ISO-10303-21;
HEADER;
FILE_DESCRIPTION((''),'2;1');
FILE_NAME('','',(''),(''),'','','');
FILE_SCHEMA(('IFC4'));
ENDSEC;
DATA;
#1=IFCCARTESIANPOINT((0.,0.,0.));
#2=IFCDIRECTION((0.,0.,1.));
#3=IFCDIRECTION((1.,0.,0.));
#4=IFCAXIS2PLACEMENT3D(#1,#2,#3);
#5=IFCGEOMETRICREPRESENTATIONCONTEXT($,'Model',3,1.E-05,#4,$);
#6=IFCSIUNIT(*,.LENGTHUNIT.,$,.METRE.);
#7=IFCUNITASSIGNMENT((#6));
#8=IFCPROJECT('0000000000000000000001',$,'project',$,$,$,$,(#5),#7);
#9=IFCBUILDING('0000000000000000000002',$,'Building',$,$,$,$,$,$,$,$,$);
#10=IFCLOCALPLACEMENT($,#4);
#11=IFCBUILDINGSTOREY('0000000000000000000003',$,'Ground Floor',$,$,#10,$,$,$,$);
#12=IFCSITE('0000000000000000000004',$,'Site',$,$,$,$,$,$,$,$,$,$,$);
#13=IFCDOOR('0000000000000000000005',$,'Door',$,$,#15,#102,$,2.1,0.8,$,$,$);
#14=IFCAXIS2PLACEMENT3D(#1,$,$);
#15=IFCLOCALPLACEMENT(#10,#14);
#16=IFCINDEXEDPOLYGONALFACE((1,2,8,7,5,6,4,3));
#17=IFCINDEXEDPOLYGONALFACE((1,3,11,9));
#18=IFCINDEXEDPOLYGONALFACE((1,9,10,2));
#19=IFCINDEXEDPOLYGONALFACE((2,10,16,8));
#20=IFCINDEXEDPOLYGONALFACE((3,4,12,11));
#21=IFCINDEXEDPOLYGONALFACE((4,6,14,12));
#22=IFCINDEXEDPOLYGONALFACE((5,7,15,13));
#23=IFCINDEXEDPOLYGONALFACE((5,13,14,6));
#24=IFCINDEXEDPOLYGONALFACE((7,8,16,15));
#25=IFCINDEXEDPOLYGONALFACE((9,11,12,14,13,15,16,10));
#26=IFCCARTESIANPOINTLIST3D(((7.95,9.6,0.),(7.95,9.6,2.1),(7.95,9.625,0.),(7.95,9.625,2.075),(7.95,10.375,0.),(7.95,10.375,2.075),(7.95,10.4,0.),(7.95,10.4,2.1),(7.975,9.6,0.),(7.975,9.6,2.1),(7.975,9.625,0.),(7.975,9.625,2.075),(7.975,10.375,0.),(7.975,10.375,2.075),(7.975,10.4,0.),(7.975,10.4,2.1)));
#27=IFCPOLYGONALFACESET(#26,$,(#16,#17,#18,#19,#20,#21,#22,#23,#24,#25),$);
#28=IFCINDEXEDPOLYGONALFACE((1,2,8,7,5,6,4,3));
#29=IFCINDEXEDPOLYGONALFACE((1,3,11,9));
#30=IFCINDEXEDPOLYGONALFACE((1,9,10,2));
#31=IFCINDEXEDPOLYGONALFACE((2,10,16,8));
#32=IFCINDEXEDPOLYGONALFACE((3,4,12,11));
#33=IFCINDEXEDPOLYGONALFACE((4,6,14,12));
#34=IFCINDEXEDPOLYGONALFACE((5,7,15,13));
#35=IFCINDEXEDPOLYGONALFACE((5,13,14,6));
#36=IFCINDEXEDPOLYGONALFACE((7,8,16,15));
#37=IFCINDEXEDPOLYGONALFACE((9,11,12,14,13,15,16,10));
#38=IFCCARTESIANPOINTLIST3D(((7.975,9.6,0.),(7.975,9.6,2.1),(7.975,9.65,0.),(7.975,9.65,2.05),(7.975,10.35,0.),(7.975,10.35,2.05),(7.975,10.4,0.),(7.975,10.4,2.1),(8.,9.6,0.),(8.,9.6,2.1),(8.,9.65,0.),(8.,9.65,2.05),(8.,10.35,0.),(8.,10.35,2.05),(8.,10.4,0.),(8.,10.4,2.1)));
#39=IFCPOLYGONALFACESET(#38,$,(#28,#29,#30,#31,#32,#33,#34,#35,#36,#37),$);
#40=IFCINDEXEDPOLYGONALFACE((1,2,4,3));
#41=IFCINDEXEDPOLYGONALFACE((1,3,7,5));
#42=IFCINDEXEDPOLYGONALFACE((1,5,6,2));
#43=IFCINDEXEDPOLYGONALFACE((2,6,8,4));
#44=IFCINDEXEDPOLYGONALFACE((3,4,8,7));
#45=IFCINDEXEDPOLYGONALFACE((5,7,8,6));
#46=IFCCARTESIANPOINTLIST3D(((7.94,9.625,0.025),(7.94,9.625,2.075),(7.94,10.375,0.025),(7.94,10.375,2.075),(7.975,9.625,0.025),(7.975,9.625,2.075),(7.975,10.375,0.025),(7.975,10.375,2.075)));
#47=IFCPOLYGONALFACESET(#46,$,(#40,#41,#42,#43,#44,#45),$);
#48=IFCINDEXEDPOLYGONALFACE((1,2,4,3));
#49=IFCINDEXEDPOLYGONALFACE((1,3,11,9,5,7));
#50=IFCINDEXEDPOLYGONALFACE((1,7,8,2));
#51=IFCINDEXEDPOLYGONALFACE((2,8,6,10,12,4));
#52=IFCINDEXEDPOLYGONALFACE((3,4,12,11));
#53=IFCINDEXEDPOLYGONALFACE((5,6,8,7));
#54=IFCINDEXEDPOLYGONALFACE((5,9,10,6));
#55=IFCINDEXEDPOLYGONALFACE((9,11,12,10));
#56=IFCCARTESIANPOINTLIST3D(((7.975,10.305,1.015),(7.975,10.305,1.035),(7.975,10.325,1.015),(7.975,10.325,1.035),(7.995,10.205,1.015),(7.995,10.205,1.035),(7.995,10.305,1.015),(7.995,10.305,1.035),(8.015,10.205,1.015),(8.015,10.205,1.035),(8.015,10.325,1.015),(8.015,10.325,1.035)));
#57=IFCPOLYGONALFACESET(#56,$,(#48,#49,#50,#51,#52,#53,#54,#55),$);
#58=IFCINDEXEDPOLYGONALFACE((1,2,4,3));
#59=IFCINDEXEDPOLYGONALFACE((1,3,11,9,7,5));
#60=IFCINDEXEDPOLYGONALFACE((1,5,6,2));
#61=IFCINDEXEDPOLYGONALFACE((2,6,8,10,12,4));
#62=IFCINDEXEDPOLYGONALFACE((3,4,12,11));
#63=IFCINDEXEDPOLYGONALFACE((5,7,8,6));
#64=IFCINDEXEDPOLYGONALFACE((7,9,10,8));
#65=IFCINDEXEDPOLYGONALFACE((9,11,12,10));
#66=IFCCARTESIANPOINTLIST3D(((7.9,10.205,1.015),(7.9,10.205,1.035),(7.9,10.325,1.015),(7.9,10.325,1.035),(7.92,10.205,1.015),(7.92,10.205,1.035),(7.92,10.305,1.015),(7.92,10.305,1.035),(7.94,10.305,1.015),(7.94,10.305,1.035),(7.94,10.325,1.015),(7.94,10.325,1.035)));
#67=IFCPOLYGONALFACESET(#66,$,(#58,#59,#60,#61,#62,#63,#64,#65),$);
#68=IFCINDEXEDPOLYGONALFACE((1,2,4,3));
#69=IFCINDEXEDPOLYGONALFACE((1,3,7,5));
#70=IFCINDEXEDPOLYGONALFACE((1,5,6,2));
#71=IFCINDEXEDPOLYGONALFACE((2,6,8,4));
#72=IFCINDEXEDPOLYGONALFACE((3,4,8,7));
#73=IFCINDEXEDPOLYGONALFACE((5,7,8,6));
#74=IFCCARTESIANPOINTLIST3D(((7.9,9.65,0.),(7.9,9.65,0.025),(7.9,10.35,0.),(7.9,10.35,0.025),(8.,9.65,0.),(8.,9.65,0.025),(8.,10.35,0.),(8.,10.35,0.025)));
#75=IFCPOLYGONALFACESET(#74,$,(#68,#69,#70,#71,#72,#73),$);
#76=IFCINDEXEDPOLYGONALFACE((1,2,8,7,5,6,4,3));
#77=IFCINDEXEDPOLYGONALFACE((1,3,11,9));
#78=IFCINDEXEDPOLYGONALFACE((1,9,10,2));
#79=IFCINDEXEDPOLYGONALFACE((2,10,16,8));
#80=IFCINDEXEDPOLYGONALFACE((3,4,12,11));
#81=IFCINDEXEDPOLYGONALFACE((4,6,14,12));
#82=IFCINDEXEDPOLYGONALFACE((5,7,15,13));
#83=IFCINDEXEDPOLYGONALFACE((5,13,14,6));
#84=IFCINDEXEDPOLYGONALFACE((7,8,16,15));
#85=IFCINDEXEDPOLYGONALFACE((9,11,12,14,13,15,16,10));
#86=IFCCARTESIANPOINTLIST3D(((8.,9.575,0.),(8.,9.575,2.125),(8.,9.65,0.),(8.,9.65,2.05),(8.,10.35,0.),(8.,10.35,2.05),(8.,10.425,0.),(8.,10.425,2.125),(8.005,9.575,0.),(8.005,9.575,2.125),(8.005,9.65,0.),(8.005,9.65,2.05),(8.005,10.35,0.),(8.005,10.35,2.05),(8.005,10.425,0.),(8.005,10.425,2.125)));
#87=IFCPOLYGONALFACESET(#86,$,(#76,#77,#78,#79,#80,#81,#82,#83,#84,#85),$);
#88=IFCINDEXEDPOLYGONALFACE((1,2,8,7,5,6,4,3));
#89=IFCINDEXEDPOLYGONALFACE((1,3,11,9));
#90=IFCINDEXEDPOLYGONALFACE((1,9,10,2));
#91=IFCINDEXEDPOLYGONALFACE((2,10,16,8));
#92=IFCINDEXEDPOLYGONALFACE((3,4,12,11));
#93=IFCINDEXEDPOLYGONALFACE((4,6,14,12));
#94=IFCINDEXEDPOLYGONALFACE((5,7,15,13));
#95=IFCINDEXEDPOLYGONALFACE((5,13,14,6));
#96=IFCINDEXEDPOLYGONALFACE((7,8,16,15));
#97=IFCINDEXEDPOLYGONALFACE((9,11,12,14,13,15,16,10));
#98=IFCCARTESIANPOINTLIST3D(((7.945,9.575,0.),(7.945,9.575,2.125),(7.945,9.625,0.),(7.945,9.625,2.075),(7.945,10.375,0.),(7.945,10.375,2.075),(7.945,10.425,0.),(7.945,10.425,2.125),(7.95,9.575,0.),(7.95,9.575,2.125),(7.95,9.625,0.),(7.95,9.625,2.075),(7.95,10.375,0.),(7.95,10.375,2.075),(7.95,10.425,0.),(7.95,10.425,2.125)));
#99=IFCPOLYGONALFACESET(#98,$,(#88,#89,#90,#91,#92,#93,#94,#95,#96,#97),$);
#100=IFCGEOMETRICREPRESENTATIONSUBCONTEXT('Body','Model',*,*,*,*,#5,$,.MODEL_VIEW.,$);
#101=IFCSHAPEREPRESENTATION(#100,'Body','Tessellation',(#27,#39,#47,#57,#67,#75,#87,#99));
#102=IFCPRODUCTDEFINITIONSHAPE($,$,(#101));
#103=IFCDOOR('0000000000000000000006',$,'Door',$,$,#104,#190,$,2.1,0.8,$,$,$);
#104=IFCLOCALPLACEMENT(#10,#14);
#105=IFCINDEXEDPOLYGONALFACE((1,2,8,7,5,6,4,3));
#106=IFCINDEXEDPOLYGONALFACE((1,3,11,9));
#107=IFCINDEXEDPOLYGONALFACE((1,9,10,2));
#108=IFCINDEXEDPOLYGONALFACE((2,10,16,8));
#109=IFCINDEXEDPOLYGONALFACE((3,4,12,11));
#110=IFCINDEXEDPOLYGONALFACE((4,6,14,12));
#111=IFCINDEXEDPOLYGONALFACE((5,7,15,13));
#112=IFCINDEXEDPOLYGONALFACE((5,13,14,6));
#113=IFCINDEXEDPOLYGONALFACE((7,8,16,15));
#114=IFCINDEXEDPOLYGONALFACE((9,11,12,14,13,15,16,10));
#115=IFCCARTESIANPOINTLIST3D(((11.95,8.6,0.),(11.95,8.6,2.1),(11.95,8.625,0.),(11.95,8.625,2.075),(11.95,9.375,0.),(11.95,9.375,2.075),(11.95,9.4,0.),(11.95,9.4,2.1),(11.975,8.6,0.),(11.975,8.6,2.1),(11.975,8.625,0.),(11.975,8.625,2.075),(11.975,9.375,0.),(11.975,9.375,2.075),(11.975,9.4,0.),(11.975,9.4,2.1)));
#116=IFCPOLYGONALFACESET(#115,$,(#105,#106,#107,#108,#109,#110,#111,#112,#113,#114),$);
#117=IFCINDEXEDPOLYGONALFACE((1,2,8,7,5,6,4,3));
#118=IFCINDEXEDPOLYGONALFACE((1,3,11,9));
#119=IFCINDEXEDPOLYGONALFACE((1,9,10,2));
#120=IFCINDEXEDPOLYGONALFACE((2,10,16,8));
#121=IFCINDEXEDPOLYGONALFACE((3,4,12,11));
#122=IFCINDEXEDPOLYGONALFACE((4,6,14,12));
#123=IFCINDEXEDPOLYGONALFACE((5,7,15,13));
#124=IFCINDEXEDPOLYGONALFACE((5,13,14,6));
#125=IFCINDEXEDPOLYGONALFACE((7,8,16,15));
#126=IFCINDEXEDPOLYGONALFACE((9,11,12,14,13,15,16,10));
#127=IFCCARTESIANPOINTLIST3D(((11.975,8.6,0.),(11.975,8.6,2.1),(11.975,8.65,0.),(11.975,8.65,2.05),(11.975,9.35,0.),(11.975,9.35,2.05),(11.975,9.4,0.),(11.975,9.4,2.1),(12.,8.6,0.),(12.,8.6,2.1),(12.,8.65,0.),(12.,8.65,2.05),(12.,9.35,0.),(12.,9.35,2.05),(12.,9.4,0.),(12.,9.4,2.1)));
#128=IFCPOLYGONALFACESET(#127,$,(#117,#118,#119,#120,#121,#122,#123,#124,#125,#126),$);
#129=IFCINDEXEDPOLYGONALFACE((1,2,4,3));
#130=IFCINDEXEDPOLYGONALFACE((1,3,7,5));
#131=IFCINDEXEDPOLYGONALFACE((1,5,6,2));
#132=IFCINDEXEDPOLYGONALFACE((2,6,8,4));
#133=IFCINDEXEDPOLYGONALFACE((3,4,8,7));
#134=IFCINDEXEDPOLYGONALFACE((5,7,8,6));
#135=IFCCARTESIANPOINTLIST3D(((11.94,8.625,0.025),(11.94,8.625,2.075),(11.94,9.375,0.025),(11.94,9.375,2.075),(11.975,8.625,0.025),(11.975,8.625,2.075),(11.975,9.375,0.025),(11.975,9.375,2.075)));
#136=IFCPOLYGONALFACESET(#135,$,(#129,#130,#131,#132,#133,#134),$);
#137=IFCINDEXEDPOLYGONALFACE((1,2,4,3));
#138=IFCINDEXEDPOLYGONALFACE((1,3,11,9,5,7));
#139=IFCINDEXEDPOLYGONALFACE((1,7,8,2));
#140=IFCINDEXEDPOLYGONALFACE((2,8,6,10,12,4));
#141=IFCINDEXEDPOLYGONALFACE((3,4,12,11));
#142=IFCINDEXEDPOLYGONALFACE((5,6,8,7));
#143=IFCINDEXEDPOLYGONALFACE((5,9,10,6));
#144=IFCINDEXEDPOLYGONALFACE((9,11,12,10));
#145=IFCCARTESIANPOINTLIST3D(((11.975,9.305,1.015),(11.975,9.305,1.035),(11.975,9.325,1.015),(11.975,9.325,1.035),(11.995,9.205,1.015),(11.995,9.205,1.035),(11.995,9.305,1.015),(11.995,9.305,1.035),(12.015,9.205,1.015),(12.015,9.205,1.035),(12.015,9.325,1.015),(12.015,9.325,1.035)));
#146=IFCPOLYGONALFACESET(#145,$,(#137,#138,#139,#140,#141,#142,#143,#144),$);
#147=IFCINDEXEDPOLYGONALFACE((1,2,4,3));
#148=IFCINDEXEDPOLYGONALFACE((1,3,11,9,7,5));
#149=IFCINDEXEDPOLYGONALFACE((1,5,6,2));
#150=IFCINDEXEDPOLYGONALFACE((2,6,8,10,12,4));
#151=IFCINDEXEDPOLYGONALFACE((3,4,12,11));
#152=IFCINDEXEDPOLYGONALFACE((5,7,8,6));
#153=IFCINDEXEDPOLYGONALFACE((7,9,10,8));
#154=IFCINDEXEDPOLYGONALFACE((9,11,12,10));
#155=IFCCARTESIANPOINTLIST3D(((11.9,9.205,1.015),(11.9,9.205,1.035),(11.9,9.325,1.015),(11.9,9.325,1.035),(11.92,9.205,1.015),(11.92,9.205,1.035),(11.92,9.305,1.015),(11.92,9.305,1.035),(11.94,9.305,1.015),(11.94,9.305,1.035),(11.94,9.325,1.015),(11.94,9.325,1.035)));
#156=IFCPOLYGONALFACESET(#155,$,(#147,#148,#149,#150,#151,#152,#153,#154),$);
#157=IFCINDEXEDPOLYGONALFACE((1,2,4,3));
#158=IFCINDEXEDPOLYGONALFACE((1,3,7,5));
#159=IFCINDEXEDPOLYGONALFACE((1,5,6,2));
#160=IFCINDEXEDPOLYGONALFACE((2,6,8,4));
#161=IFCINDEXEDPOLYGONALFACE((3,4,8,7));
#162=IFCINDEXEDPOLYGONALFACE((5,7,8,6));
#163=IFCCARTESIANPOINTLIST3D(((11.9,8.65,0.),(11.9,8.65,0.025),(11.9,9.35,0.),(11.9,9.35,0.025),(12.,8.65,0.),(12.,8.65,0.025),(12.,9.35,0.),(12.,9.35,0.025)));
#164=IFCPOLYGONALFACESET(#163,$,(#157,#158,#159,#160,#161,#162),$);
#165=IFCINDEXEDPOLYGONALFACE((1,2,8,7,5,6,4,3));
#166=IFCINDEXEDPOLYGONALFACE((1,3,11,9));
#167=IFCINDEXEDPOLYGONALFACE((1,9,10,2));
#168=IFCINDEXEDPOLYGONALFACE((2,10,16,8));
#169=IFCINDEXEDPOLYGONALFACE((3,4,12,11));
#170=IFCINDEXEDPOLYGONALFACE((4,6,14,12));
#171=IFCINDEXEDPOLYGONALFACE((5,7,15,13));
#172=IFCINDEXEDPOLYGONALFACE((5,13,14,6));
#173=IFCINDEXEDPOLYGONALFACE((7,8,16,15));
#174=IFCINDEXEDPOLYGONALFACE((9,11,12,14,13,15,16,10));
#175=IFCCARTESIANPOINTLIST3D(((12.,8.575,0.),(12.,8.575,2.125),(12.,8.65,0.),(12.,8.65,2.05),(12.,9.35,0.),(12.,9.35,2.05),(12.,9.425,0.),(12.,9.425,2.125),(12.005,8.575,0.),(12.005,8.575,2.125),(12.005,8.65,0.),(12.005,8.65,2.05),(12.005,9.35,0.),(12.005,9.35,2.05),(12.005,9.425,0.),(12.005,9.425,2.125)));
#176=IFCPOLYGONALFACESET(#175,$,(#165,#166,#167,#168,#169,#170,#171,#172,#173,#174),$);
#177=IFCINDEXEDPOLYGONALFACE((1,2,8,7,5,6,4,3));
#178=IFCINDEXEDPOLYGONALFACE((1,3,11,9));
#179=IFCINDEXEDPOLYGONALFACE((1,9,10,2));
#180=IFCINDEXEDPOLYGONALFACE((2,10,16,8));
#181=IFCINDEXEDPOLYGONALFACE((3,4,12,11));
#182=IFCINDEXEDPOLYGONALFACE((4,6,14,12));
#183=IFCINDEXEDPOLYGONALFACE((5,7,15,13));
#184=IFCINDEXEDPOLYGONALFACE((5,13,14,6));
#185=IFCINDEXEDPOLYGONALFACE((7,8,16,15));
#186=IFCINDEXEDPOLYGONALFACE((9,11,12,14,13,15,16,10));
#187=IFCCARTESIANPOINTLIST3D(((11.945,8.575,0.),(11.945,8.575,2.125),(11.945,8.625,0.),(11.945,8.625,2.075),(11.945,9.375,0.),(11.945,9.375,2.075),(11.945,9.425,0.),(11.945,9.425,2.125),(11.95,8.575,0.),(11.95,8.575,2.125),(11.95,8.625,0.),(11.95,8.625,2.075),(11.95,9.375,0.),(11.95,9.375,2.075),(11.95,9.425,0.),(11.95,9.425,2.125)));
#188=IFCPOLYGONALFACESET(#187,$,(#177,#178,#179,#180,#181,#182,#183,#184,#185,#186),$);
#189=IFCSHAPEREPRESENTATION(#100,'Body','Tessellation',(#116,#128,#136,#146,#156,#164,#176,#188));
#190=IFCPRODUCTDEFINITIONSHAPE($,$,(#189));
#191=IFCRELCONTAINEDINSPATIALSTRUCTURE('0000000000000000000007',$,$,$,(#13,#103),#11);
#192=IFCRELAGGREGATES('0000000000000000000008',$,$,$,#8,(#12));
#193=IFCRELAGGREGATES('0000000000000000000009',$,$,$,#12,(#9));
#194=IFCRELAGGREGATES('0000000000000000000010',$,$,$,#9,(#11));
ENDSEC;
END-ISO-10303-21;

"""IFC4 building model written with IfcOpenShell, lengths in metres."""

from ifc_helpers import new_model, si_unit, frame, origin_with_axes, place, context, subcontext, project, spatial, line, indexed_curve, outline, extrude, element, save


model = new_model("IFC4")

# Units and contexts
model_context = context("Model", 3, precision=1e-05, world=origin_with_axes())
body_context = subcontext(model_context, "Body", "Model", "MODEL_VIEW")
ifc_project = project(units=[si_unit("LENGTHUNIT", "METRE")], contexts=[model_context])

# Site, building, storey
site = spatial("IfcSite", under=ifc_project, Name="Site")
building = spatial("IfcBuilding", under=site, Name="Building")
storey_placement = place(None, origin_with_axes())
storey = spatial("IfcBuildingStorey", under=building, at=storey_placement, Name="Ground Floor")

# Doors
door_1_placement = place(storey_placement, frame((8.0, 9.6, 0.0), z_axis=(0.0, 0.0, 1.0), x_axis=(0.0, 1.0, 0.0)))
element("IfcDoor", 1, at=door_1_placement, inside=storey, Name="Door", OverallHeight=2.1, OverallWidth=0.8, context=body_context, shape_type="SweptSolid", body=[
    extrude(outline(indexed_curve([(0.0, 0.0), (0.0, 2.1), (0.8, 2.1), (0.8, 0.0), (0.775, 0.0), (0.775, 2.075), (0.025, 2.075), (0.025, 0.0)], segments=[line(1, 2, 3, 4, 5, 6, 7, 8, 1)])), frame((0.0, 0.025, 0.0), z_axis=(0.0, -1.0, 0.0), x_axis=(1.0, 0.0, 0.0)), (0.0, 0.0, -1.0), 0.025),
    extrude(outline(indexed_curve([(0.0, 0.0), (0.0, 2.1), (0.8, 2.1), (0.8, 0.0), (0.75, 0.0), (0.75, 2.05), (0.05, 2.05), (0.05, 0.0)], segments=[line(1, 2, 3, 4, 5, 6, 7, 8, 1)])), frame((0.0, 0.0, 0.0), z_axis=(0.0, -1.0, 0.0), x_axis=(1.0, 0.0, 0.0)), (0.0, 0.0, -1.0), 0.025),
    extrude(outline(indexed_curve([(0.0, 0.0), (0.75, 0.0), (0.75, 0.035), (0.0, 0.035)], segments=[line(1, 2, 3, 4, 1)])), frame((0.025, 0.025, 0.025), z_axis=(0.0, 0.0, 1.0), x_axis=(1.0, 0.0, 0.0)), (0.0, 0.0, 1.0), 2.05),
    extrude(outline(indexed_curve([(0.0, 0.0), (0.0, -0.04), (-0.12, -0.04), (-0.12, -0.02), (-0.02, -0.02), (-0.02, 0.0)], segments=[line(1, 2, 3, 4, 5, 6, 1)])), frame((0.725, 0.025, 1.015), z_axis=(0.0, 0.0, 1.0), x_axis=(1.0, 0.0, 0.0)), (0.0, 0.0, 1.0), 0.02),
    extrude(outline(indexed_curve([(0.0, 0.0), (0.0, 0.04), (-0.12, 0.04), (-0.12, 0.02), (-0.02, 0.02), (-0.02, 0.0)], segments=[line(1, 2, 3, 4, 5, 6, 1)])), frame((0.725, 0.06, 1.015), z_axis=(0.0, 0.0, 1.0), x_axis=(1.0, 0.0, 0.0)), (0.0, 0.0, 1.0), 0.02),
    extrude(outline(indexed_curve([(0.0, 0.0), (0.7, 0.0), (0.7, 0.1), (0.0, 0.1)], segments=[line(1, 2, 3, 4, 1)])), frame((0.05, 0.0, 0.0), z_axis=(0.0, 0.0, 1.0), x_axis=(1.0, 0.0, 0.0)), (0.0, 0.0, 1.0), 0.025),
    extrude(outline(indexed_curve([(0.0, 0.0), (0.0, 2.125), (0.85, 2.125), (0.85, 0.0), (0.775, 0.0), (0.775, 2.05), (0.075, 2.05), (0.075, 0.0)], segments=[line(1, 2, 3, 4, 5, 6, 7, 8, 1)])), frame((-0.025, -0.005, 0.0), z_axis=(0.0, -1.0, 0.0), x_axis=(1.0, 0.0, 0.0)), (0.0, 0.0, -1.0), 0.005),
    extrude(outline(indexed_curve([(0.0, 0.0), (0.0, 2.125), (0.85, 2.125), (0.85, 0.0), (0.8, 0.0), (0.8, 2.075), (0.05, 2.075), (0.05, 0.0)], segments=[line(1, 2, 3, 4, 5, 6, 7, 8, 1)])), frame((-0.025, 0.05, 0.0), z_axis=(0.0, -1.0, 0.0), x_axis=(1.0, 0.0, 0.0)), (0.0, 0.0, -1.0), 0.005),
])
door_2_placement = place(storey_placement, frame((12.0, 8.6, 0.0), z_axis=(0.0, 0.0, 1.0), x_axis=(0.0, 1.0, 0.0)))
element("IfcDoor", 2, at=door_2_placement, inside=storey, Name="Door", OverallHeight=2.1, OverallWidth=0.8, context=body_context, shape_type="SweptSolid", body=[
    extrude(outline(indexed_curve([(0.0, 0.0), (0.0, 2.1), (0.8, 2.1), (0.8, 0.0), (0.775, 0.0), (0.775, 2.075), (0.025, 2.075), (0.025, 0.0)], segments=[line(1, 2, 3, 4, 5, 6, 7, 8, 1)])), frame((0.0, 0.025, 0.0), z_axis=(0.0, -1.0, 0.0), x_axis=(1.0, 0.0, 0.0)), (0.0, 0.0, -1.0), 0.025),
    extrude(outline(indexed_curve([(0.0, 0.0), (0.0, 2.1), (0.8, 2.1), (0.8, 0.0), (0.75, 0.0), (0.75, 2.05), (0.05, 2.05), (0.05, 0.0)], segments=[line(1, 2, 3, 4, 5, 6, 7, 8, 1)])), frame((0.0, 0.0, 0.0), z_axis=(0.0, -1.0, 0.0), x_axis=(1.0, 0.0, 0.0)), (0.0, 0.0, -1.0), 0.025),
    extrude(outline(indexed_curve([(0.0, 0.0), (0.75, 0.0), (0.75, 0.035), (0.0, 0.035)], segments=[line(1, 2, 3, 4, 1)])), frame((0.025, 0.025, 0.025), z_axis=(0.0, 0.0, 1.0), x_axis=(1.0, 0.0, 0.0)), (0.0, 0.0, 1.0), 2.05),
    extrude(outline(indexed_curve([(0.0, 0.0), (0.0, -0.04), (-0.12, -0.04), (-0.12, -0.02), (-0.02, -0.02), (-0.02, 0.0)], segments=[line(1, 2, 3, 4, 5, 6, 1)])), frame((0.725, 0.025, 1.015), z_axis=(0.0, 0.0, 1.0), x_axis=(1.0, 0.0, 0.0)), (0.0, 0.0, 1.0), 0.02),
    extrude(outline(indexed_curve([(0.0, 0.0), (0.0, 0.04), (-0.12, 0.04), (-0.12, 0.02), (-0.02, 0.02), (-0.02, 0.0)], segments=[line(1, 2, 3, 4, 5, 6, 1)])), frame((0.725, 0.06, 1.015), z_axis=(0.0, 0.0, 1.0), x_axis=(1.0, 0.0, 0.0)), (0.0, 0.0, 1.0), 0.02),
    extrude(outline(indexed_curve([(0.0, 0.0), (0.7, 0.0), (0.7, 0.1), (0.0, 0.1)], segments=[line(1, 2, 3, 4, 1)])), frame((0.05, 0.0, 0.0), z_axis=(0.0, 0.0, 1.0), x_axis=(1.0, 0.0, 0.0)), (0.0, 0.0, 1.0), 0.025),
    extrude(outline(indexed_curve([(0.0, 0.0), (0.0, 2.125), (0.85, 2.125), (0.85, 0.0), (0.775, 0.0), (0.775, 2.05), (0.075, 2.05), (0.075, 0.0)], segments=[line(1, 2, 3, 4, 5, 6, 7, 8, 1)])), frame((-0.025, -0.005, 0.0), z_axis=(0.0, -1.0, 0.0), x_axis=(1.0, 0.0, 0.0)), (0.0, 0.0, -1.0), 0.005),
    extrude(outline(indexed_curve([(0.0, 0.0), (0.0, 2.125), (0.85, 2.125), (0.85, 0.0), (0.8, 0.0), (0.8, 2.075), (0.05, 2.075), (0.05, 0.0)], segments=[line(1, 2, 3, 4, 5, 6, 7, 8, 1)])), frame((-0.025, 0.05, 0.0), z_axis=(0.0, -1.0, 0.0), x_axis=(1.0, 0.0, 0.0)), (0.0, 0.0, -1.0), 0.005),
])

save(model, "model.ifc")
